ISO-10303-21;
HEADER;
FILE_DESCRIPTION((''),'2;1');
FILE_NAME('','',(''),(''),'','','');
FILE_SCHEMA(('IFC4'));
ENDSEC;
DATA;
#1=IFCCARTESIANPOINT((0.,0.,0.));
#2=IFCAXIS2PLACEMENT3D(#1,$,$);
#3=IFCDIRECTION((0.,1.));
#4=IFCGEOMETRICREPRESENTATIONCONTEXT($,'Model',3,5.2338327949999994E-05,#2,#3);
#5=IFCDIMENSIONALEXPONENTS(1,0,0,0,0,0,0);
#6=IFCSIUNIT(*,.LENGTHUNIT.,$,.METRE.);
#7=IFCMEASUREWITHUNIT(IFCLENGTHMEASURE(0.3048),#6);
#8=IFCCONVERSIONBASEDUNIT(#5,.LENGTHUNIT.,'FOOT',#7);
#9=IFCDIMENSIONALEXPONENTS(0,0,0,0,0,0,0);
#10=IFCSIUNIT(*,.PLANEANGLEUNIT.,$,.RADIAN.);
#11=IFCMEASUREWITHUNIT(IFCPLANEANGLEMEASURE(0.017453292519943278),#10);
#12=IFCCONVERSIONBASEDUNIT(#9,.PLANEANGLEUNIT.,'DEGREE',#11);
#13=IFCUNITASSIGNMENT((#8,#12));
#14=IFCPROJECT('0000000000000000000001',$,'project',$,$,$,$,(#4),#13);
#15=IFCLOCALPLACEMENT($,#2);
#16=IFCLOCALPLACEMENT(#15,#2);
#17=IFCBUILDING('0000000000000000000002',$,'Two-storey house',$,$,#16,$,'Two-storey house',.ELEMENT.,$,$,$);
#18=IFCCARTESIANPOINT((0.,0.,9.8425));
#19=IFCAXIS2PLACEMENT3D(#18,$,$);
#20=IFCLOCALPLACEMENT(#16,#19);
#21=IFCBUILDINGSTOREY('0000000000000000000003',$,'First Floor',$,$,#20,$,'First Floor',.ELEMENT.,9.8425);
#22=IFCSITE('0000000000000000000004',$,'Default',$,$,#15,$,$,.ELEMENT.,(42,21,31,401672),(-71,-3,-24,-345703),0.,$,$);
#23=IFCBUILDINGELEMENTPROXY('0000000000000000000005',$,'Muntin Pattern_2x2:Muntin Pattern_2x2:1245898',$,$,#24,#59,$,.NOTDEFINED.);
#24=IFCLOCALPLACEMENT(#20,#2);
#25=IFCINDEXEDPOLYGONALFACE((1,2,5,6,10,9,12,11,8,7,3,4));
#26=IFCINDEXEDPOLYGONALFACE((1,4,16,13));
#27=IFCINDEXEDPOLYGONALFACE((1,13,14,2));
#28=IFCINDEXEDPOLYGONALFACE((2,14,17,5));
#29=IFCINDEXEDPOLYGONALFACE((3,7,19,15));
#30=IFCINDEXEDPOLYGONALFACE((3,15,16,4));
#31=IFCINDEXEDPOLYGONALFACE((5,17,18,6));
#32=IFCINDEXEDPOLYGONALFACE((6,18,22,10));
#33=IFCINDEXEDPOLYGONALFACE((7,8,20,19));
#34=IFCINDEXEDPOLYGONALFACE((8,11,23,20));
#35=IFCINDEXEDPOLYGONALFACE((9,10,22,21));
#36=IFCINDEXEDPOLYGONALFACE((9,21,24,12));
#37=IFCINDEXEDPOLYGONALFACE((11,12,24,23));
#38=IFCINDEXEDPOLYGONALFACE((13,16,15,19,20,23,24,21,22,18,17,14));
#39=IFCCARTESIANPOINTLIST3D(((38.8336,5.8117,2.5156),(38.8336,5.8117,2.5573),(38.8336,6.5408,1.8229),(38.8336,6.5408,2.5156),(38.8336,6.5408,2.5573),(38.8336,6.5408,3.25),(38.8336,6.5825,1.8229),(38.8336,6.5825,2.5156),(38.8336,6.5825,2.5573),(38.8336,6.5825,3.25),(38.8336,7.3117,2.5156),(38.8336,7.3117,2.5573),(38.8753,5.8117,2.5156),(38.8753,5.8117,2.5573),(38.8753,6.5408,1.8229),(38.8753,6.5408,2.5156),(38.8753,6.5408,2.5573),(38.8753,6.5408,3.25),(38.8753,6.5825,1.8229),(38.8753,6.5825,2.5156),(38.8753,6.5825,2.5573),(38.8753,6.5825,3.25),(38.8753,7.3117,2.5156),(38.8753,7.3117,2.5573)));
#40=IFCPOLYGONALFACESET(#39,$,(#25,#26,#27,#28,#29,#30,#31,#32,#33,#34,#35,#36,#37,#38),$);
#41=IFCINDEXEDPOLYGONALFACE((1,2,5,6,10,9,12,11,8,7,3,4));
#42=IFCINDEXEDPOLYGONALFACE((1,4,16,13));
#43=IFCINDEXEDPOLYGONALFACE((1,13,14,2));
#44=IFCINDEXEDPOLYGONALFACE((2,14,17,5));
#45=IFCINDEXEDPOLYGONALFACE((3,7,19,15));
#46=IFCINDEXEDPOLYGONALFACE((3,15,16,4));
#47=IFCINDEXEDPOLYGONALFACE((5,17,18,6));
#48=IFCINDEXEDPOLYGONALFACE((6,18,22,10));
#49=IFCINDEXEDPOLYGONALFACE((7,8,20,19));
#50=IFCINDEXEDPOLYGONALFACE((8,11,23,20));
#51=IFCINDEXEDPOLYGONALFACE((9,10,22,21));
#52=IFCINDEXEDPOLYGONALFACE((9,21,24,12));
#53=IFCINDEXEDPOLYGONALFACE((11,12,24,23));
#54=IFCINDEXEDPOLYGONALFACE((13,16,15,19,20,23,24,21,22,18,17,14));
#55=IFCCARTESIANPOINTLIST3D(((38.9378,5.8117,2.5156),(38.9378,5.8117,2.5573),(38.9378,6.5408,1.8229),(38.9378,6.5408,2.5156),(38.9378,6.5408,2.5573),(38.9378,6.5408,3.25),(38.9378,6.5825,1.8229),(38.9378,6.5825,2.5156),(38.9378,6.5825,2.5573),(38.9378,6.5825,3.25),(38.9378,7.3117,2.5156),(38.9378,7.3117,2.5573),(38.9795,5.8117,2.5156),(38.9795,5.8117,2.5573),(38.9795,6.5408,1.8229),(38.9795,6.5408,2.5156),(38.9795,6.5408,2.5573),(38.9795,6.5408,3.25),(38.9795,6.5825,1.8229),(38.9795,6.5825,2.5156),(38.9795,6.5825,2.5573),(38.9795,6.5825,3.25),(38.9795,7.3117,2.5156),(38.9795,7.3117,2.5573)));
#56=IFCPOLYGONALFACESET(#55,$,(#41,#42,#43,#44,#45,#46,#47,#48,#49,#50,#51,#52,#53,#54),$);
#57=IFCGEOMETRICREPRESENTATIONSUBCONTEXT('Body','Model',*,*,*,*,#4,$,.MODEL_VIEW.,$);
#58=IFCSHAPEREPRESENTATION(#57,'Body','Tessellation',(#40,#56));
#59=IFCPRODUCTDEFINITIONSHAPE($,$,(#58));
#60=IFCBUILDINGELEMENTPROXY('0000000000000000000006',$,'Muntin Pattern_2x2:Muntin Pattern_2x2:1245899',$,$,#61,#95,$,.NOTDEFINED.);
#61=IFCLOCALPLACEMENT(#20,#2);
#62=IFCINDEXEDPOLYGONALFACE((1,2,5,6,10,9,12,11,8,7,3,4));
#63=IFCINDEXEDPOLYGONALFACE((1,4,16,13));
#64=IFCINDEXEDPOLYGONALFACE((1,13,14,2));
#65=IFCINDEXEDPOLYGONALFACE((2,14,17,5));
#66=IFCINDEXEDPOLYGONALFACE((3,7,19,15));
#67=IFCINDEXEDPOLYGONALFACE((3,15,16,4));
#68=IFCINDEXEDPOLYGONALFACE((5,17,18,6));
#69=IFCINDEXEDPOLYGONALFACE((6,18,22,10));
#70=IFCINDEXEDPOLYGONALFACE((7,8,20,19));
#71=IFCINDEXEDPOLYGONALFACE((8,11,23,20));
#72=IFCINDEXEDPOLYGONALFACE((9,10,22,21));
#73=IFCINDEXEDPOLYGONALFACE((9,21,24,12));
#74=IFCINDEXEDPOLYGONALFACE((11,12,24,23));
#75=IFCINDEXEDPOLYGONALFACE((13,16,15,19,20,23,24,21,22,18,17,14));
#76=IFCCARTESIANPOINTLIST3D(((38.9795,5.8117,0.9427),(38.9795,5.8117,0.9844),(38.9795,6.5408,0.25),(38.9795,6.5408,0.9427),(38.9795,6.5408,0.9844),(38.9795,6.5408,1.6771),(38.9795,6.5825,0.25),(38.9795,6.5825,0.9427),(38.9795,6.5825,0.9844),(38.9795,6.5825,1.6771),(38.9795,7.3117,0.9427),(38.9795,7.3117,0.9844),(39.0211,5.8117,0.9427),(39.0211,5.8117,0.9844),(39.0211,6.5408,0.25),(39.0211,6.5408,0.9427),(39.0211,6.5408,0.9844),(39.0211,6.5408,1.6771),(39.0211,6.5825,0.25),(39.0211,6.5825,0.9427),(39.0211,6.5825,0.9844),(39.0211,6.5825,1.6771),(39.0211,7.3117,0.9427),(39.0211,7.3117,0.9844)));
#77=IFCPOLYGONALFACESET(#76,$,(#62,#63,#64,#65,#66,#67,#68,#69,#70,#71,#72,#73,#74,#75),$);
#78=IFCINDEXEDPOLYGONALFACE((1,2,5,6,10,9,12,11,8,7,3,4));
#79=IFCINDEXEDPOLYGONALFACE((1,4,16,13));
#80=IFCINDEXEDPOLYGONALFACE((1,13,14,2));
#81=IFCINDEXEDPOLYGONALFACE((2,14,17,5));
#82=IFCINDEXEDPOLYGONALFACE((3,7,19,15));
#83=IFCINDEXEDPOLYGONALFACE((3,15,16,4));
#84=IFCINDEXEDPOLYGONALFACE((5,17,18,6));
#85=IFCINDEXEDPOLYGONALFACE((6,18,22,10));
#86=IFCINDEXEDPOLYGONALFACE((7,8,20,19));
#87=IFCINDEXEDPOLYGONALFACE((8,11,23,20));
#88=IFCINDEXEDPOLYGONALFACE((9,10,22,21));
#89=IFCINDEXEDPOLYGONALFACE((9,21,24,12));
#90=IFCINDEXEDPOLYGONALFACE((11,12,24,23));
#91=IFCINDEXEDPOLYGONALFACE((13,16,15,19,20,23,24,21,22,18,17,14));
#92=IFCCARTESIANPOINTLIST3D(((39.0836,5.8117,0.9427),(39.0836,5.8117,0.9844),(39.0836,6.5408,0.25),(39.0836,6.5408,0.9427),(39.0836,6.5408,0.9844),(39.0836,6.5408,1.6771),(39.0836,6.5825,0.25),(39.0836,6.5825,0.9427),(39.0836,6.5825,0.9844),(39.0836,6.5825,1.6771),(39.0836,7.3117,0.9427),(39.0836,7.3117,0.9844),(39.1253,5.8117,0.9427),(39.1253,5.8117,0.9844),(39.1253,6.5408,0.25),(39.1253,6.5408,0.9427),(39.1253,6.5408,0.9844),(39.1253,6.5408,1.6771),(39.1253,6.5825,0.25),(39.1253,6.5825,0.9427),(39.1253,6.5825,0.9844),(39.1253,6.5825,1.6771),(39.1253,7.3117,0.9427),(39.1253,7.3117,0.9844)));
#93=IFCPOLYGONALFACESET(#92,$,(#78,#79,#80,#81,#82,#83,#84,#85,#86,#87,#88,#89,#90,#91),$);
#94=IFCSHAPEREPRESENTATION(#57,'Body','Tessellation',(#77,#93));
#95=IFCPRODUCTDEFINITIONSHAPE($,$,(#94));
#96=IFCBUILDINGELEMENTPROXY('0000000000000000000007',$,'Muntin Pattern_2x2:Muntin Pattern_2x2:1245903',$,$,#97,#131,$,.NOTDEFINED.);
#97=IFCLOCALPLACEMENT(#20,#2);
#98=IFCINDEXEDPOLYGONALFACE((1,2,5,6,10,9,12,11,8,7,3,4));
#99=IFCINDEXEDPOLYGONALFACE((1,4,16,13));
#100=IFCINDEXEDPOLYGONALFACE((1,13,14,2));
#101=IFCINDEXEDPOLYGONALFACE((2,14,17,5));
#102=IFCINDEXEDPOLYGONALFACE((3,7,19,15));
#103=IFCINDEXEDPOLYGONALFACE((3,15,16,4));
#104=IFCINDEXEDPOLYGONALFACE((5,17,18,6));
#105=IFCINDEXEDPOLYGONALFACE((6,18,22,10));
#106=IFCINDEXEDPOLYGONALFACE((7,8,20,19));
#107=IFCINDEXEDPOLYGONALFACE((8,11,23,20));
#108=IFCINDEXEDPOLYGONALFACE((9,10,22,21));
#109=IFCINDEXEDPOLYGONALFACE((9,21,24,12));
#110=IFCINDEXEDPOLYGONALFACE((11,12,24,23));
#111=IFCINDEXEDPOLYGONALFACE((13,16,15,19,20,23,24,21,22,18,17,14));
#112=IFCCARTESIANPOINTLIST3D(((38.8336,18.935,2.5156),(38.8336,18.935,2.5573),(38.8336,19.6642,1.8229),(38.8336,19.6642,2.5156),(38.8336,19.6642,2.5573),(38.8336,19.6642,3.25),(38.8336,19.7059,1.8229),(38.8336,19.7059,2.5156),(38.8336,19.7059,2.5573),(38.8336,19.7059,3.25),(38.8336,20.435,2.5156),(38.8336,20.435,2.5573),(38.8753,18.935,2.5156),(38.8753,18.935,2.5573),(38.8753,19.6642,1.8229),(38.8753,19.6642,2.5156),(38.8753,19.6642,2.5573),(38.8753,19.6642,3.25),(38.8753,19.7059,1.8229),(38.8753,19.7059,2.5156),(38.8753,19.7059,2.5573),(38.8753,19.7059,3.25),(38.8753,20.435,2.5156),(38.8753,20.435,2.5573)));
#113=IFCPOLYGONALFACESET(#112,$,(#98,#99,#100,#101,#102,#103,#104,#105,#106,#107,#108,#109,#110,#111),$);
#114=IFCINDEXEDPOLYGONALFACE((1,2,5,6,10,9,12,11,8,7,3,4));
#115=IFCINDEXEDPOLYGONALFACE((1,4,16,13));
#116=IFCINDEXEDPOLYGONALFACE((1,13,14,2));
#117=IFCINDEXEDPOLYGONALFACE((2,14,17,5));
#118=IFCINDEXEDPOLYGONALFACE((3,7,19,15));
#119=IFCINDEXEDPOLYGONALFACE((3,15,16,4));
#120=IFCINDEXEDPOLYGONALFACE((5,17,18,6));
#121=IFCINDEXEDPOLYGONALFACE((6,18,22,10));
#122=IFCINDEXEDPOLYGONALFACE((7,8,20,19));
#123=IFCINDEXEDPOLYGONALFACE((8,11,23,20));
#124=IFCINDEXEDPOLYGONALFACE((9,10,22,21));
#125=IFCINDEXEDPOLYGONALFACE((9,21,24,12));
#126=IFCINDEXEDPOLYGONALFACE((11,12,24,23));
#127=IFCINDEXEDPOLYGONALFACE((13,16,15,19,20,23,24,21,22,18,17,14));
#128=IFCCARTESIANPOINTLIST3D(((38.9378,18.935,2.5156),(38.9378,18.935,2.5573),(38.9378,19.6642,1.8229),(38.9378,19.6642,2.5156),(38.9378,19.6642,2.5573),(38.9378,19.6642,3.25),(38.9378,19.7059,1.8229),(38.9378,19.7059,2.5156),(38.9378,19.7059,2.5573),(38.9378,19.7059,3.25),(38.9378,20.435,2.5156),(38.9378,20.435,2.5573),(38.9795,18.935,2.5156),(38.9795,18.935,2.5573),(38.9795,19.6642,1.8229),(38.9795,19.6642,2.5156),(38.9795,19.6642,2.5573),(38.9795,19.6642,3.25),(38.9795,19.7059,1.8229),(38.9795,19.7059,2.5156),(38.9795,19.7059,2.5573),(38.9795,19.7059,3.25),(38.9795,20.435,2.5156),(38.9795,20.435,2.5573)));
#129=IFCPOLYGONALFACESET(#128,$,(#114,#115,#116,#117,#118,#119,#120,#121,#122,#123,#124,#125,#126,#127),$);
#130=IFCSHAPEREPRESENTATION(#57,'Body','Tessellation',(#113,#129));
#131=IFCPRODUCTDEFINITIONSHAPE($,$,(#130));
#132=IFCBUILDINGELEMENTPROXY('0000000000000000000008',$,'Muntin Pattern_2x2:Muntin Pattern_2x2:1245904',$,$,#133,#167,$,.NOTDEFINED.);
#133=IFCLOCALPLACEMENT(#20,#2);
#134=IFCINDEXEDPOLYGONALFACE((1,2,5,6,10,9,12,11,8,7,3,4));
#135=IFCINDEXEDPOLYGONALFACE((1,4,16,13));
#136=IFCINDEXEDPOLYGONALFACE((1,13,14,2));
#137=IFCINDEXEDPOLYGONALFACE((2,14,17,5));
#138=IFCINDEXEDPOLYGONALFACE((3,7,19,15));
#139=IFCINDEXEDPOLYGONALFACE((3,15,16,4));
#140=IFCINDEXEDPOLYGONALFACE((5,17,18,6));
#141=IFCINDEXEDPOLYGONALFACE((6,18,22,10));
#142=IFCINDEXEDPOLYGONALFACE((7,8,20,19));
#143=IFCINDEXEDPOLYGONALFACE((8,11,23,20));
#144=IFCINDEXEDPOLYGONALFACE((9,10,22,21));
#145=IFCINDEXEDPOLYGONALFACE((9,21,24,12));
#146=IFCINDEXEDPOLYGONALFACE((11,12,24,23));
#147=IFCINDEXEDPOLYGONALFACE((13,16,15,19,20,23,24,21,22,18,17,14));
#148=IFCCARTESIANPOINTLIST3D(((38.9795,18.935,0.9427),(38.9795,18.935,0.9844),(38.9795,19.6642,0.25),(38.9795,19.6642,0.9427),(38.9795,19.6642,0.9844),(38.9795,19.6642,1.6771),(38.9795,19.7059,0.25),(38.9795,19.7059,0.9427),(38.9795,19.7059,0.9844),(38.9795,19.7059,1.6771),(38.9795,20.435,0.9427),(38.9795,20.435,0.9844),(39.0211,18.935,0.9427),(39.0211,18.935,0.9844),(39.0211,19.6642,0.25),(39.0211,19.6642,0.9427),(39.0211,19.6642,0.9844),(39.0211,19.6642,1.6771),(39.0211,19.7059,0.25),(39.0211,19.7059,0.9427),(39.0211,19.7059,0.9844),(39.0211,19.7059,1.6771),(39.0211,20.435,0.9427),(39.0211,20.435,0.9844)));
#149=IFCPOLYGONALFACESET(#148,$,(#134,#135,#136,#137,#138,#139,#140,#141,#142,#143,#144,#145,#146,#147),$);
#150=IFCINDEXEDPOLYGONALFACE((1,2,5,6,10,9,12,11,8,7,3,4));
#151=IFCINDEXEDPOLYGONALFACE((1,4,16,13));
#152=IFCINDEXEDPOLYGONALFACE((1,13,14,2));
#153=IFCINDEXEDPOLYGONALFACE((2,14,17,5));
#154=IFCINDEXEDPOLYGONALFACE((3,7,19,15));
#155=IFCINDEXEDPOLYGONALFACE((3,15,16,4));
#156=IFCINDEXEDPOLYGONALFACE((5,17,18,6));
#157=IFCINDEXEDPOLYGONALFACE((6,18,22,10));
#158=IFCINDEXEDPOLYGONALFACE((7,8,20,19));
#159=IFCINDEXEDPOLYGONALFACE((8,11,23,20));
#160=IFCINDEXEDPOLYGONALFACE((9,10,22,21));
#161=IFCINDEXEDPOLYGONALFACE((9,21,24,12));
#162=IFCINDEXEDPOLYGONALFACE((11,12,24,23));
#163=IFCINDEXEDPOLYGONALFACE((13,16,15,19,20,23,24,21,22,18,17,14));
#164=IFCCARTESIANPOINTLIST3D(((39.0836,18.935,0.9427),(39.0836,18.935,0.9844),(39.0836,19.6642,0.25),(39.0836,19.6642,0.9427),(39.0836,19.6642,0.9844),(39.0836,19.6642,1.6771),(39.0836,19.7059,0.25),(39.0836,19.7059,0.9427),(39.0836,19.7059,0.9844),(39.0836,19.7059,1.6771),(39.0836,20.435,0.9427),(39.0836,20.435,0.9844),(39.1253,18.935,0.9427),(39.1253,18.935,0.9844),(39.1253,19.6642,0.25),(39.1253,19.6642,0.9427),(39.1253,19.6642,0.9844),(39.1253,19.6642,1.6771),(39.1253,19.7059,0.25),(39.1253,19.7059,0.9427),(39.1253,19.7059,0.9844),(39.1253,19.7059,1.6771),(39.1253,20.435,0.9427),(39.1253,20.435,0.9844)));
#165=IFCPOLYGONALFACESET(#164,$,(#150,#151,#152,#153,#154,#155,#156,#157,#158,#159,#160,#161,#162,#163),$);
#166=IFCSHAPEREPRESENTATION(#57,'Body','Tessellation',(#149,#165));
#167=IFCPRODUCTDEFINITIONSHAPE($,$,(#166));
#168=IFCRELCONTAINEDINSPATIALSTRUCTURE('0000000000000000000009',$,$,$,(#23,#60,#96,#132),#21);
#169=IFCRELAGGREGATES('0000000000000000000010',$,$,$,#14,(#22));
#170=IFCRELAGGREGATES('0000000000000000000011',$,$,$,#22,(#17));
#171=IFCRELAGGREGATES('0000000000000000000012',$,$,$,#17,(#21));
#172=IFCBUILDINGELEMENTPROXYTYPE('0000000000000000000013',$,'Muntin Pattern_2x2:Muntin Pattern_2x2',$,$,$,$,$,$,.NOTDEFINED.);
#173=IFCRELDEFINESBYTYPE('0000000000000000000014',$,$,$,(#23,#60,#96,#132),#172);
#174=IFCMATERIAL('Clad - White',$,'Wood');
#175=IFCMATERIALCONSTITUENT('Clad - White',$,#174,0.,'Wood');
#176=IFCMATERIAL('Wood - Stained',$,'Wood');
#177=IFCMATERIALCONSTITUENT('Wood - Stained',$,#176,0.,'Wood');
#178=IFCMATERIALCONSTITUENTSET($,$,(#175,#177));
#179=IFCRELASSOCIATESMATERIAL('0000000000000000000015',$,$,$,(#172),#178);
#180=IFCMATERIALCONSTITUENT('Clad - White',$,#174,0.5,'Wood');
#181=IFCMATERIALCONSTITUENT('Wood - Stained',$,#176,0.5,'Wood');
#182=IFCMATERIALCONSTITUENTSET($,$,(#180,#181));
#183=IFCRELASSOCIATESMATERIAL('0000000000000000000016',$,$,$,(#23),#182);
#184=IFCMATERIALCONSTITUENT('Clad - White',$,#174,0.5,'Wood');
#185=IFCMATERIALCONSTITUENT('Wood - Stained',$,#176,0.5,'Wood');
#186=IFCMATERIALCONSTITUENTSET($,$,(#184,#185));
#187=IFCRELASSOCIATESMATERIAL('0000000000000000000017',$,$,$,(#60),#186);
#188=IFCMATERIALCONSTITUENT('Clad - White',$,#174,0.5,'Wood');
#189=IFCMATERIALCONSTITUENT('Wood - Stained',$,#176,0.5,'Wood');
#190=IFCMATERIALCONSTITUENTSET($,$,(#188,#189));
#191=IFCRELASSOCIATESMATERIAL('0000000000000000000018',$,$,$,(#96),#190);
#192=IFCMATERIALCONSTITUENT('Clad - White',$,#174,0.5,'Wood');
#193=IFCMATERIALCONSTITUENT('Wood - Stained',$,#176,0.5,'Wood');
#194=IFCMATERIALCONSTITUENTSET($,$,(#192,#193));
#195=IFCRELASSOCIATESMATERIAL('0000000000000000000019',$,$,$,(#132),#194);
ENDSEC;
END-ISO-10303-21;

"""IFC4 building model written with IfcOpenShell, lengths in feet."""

from ifc_helpers import new_model, entity, si_unit, converted_unit, direction, frame, origin, place, context, subcontext, project, spatial, indexed_curve, outline, extrude, source, transform, mapped, material, constituent, constituent_set, type_object, type_shapes, element, save


model = new_model("IFC4")

# Units and contexts
model_context = context("Model", 3, precision=5.2338327949999994e-05, world=origin(), true_north=direction((0.0, 1.0)))
body_context = subcontext(model_context, "Body", "Model", "MODEL_VIEW")
ifc_project = project(units=[converted_unit("LENGTHUNIT", "FOOT", entity("IfcLengthMeasure", 0.3048), si_unit("LENGTHUNIT", "METRE"), dimensions=[1, 0, 0, 0, 0, 0, 0]), converted_unit("PLANEANGLEUNIT", "DEGREE", entity("IfcPlaneAngleMeasure", 0.017453292519943278), si_unit("PLANEANGLEUNIT", "RADIAN"), dimensions=[0, 0, 0, 0, 0, 0, 0])], contexts=[model_context])

# Site, building, storey
site_placement = place(None, origin())
site = spatial("IfcSite", under=ifc_project, at=site_placement, Name="Default", CompositionType="ELEMENT", RefLatitude=(42, 21, 31, 401672), RefLongitude=(-71, -3, -24, -345703), RefElevation=0.0)
building_placement = place(site_placement, origin())
building = spatial("IfcBuilding", under=site, at=building_placement, Name="Two-storey house", LongName="Two-storey house", CompositionType="ELEMENT")
storey_placement = place(building_placement, frame((0.0, 0.0, 9.8425)))
storey = spatial("IfcBuildingStorey", under=building, at=storey_placement, Name="First Floor", LongName="First Floor", CompositionType="ELEMENT", Elevation=9.8425)

# Shared definitions
ifc_material_1 = material(Name="Wood - Stained", Category="Wood")

# Building element proxies
ifc_material_2 = material(Name="Clad - White", Category="Wood")
ifc_constituent_1 = constituent(ifc_material_2, Name="Clad - White", Category="Wood", fraction=0.5)
ifc_constituent_2 = constituent(ifc_material_1, Name="Wood - Stained", Category="Wood", fraction=0.5)
ifc_constituent_set_1 = constituent_set(constituents=[ifc_constituent_1, ifc_constituent_2])
ifc_constituent_3 = constituent(ifc_material_2, Name="Clad - White", Category="Wood", fraction=0.0)
ifc_constituent_4 = constituent(ifc_material_1, Name="Wood - Stained", Category="Wood", fraction=0.0)
ifc_constituent_set_2 = constituent_set(constituents=[ifc_constituent_3, ifc_constituent_4])
building_element_proxy_type_1 = type_object("IfcBuildingElementProxyType", Name="Muntin Pattern_2x2:Muntin Pattern_2x2", PredefinedType="NOTDEFINED", material=ifc_constituent_set_2)
shared_shape_1 = source(origin(), body_context, "Body", "SweptSolid", [
    extrude(outline(indexed_curve([(0.0208, -0.0208), (0.7135, -0.0208), (0.7135, 0.0208), (0.0208, 0.0208), (0.0208, 0.75), (-0.0208, 0.75), (-0.0208, 0.0208), (-0.7135, 0.0208), (-0.7135, -0.0208), (-0.0208, -0.0208), (-0.0208, -0.75), (0.0208, -0.75), (0.0208, -0.0208)], self_intersect=False)), frame((0.0, 0.0312, 0.7135), z_axis=(0.0, 1.0, 0.0), x_axis=(0.0, 0.0, 1.0)), (0.0, 0.0, 1.0), 0.0417),
    extrude(outline(indexed_curve([(0.0208, -0.0208), (0.7135, -0.0208), (0.7135, 0.0208), (0.0208, 0.0208), (0.0208, 0.75), (-0.0208, 0.75), (-0.0208, 0.0208), (-0.7135, 0.0208), (-0.7135, -0.0208), (-0.0208, -0.0208), (-0.0208, -0.75), (0.0208, -0.75), (0.0208, -0.0208)], self_intersect=False)), frame((0.0, -0.0729, 0.7135), z_axis=(0.0, 1.0, 0.0), x_axis=(0.0, 0.0, 1.0)), (0.0, 0.0, 1.0), 0.0417),
])
type_shapes(building_element_proxy_type_1, [shared_shape_1])
proxy_1_placement = place(storey_placement, frame((38.9065, 6.5617, 1.8229), z_axis=(0.0, 0.0, 1.0), x_axis=(0.0, 1.0, 0.0)))
element("IfcBuildingElementProxy", 1, at=proxy_1_placement, inside=storey, type_object=building_element_proxy_type_1, material=ifc_constituent_set_1, Name="Muntin Pattern_2x2:Muntin Pattern_2x2:1245898", PredefinedType="NOTDEFINED", context=body_context, shape_type="MappedRepresentation", body=[
    mapped(shared_shape_1, transform((0.0, 0.0, 0.0), scale=1.0)),
])
ifc_constituent_5 = constituent(ifc_material_2, Name="Clad - White", Category="Wood", fraction=0.5)
ifc_constituent_6 = constituent(ifc_material_1, Name="Wood - Stained", Category="Wood", fraction=0.5)
ifc_constituent_set_3 = constituent_set(constituents=[ifc_constituent_5, ifc_constituent_6])
proxy_2_placement = place(storey_placement, frame((39.0524, 6.5617, 0.25), z_axis=(0.0, 0.0, 1.0), x_axis=(0.0, 1.0, 0.0)))
element("IfcBuildingElementProxy", 2, at=proxy_2_placement, inside=storey, type_object=building_element_proxy_type_1, material=ifc_constituent_set_3, Name="Muntin Pattern_2x2:Muntin Pattern_2x2:1245899", PredefinedType="NOTDEFINED", context=body_context, shape_type="MappedRepresentation", body=[
    mapped(shared_shape_1, transform((0.0, 0.0, 0.0), scale=1.0)),
])
ifc_constituent_7 = constituent(ifc_material_2, Name="Clad - White", Category="Wood", fraction=0.5)
ifc_constituent_8 = constituent(ifc_material_1, Name="Wood - Stained", Category="Wood", fraction=0.5)
ifc_constituent_set_4 = constituent_set(constituents=[ifc_constituent_7, ifc_constituent_8])
proxy_3_placement = place(storey_placement, frame((38.9065, 19.685, 1.8229), z_axis=(0.0, 0.0, 1.0), x_axis=(0.0, 1.0, 0.0)))
element("IfcBuildingElementProxy", 3, at=proxy_3_placement, inside=storey, type_object=building_element_proxy_type_1, material=ifc_constituent_set_4, Name="Muntin Pattern_2x2:Muntin Pattern_2x2:1245903", PredefinedType="NOTDEFINED", context=body_context, shape_type="MappedRepresentation", body=[
    mapped(shared_shape_1, transform((0.0, 0.0, 0.0), scale=1.0)),
])
ifc_constituent_9 = constituent(ifc_material_2, Name="Clad - White", Category="Wood", fraction=0.5)
ifc_constituent_10 = constituent(ifc_material_1, Name="Wood - Stained", Category="Wood", fraction=0.5)
ifc_constituent_set_5 = constituent_set(constituents=[ifc_constituent_9, ifc_constituent_10])
proxy_4_placement = place(storey_placement, frame((39.0524, 19.685, 0.25), z_axis=(0.0, 0.0, 1.0), x_axis=(0.0, 1.0, 0.0)))
element("IfcBuildingElementProxy", 4, at=proxy_4_placement, inside=storey, type_object=building_element_proxy_type_1, material=ifc_constituent_set_5, Name="Muntin Pattern_2x2:Muntin Pattern_2x2:1245904", PredefinedType="NOTDEFINED", context=body_context, shape_type="MappedRepresentation", body=[
    mapped(shared_shape_1, transform((0.0, 0.0, 0.0), scale=1.0)),
])

save(model, "model.ifc")
